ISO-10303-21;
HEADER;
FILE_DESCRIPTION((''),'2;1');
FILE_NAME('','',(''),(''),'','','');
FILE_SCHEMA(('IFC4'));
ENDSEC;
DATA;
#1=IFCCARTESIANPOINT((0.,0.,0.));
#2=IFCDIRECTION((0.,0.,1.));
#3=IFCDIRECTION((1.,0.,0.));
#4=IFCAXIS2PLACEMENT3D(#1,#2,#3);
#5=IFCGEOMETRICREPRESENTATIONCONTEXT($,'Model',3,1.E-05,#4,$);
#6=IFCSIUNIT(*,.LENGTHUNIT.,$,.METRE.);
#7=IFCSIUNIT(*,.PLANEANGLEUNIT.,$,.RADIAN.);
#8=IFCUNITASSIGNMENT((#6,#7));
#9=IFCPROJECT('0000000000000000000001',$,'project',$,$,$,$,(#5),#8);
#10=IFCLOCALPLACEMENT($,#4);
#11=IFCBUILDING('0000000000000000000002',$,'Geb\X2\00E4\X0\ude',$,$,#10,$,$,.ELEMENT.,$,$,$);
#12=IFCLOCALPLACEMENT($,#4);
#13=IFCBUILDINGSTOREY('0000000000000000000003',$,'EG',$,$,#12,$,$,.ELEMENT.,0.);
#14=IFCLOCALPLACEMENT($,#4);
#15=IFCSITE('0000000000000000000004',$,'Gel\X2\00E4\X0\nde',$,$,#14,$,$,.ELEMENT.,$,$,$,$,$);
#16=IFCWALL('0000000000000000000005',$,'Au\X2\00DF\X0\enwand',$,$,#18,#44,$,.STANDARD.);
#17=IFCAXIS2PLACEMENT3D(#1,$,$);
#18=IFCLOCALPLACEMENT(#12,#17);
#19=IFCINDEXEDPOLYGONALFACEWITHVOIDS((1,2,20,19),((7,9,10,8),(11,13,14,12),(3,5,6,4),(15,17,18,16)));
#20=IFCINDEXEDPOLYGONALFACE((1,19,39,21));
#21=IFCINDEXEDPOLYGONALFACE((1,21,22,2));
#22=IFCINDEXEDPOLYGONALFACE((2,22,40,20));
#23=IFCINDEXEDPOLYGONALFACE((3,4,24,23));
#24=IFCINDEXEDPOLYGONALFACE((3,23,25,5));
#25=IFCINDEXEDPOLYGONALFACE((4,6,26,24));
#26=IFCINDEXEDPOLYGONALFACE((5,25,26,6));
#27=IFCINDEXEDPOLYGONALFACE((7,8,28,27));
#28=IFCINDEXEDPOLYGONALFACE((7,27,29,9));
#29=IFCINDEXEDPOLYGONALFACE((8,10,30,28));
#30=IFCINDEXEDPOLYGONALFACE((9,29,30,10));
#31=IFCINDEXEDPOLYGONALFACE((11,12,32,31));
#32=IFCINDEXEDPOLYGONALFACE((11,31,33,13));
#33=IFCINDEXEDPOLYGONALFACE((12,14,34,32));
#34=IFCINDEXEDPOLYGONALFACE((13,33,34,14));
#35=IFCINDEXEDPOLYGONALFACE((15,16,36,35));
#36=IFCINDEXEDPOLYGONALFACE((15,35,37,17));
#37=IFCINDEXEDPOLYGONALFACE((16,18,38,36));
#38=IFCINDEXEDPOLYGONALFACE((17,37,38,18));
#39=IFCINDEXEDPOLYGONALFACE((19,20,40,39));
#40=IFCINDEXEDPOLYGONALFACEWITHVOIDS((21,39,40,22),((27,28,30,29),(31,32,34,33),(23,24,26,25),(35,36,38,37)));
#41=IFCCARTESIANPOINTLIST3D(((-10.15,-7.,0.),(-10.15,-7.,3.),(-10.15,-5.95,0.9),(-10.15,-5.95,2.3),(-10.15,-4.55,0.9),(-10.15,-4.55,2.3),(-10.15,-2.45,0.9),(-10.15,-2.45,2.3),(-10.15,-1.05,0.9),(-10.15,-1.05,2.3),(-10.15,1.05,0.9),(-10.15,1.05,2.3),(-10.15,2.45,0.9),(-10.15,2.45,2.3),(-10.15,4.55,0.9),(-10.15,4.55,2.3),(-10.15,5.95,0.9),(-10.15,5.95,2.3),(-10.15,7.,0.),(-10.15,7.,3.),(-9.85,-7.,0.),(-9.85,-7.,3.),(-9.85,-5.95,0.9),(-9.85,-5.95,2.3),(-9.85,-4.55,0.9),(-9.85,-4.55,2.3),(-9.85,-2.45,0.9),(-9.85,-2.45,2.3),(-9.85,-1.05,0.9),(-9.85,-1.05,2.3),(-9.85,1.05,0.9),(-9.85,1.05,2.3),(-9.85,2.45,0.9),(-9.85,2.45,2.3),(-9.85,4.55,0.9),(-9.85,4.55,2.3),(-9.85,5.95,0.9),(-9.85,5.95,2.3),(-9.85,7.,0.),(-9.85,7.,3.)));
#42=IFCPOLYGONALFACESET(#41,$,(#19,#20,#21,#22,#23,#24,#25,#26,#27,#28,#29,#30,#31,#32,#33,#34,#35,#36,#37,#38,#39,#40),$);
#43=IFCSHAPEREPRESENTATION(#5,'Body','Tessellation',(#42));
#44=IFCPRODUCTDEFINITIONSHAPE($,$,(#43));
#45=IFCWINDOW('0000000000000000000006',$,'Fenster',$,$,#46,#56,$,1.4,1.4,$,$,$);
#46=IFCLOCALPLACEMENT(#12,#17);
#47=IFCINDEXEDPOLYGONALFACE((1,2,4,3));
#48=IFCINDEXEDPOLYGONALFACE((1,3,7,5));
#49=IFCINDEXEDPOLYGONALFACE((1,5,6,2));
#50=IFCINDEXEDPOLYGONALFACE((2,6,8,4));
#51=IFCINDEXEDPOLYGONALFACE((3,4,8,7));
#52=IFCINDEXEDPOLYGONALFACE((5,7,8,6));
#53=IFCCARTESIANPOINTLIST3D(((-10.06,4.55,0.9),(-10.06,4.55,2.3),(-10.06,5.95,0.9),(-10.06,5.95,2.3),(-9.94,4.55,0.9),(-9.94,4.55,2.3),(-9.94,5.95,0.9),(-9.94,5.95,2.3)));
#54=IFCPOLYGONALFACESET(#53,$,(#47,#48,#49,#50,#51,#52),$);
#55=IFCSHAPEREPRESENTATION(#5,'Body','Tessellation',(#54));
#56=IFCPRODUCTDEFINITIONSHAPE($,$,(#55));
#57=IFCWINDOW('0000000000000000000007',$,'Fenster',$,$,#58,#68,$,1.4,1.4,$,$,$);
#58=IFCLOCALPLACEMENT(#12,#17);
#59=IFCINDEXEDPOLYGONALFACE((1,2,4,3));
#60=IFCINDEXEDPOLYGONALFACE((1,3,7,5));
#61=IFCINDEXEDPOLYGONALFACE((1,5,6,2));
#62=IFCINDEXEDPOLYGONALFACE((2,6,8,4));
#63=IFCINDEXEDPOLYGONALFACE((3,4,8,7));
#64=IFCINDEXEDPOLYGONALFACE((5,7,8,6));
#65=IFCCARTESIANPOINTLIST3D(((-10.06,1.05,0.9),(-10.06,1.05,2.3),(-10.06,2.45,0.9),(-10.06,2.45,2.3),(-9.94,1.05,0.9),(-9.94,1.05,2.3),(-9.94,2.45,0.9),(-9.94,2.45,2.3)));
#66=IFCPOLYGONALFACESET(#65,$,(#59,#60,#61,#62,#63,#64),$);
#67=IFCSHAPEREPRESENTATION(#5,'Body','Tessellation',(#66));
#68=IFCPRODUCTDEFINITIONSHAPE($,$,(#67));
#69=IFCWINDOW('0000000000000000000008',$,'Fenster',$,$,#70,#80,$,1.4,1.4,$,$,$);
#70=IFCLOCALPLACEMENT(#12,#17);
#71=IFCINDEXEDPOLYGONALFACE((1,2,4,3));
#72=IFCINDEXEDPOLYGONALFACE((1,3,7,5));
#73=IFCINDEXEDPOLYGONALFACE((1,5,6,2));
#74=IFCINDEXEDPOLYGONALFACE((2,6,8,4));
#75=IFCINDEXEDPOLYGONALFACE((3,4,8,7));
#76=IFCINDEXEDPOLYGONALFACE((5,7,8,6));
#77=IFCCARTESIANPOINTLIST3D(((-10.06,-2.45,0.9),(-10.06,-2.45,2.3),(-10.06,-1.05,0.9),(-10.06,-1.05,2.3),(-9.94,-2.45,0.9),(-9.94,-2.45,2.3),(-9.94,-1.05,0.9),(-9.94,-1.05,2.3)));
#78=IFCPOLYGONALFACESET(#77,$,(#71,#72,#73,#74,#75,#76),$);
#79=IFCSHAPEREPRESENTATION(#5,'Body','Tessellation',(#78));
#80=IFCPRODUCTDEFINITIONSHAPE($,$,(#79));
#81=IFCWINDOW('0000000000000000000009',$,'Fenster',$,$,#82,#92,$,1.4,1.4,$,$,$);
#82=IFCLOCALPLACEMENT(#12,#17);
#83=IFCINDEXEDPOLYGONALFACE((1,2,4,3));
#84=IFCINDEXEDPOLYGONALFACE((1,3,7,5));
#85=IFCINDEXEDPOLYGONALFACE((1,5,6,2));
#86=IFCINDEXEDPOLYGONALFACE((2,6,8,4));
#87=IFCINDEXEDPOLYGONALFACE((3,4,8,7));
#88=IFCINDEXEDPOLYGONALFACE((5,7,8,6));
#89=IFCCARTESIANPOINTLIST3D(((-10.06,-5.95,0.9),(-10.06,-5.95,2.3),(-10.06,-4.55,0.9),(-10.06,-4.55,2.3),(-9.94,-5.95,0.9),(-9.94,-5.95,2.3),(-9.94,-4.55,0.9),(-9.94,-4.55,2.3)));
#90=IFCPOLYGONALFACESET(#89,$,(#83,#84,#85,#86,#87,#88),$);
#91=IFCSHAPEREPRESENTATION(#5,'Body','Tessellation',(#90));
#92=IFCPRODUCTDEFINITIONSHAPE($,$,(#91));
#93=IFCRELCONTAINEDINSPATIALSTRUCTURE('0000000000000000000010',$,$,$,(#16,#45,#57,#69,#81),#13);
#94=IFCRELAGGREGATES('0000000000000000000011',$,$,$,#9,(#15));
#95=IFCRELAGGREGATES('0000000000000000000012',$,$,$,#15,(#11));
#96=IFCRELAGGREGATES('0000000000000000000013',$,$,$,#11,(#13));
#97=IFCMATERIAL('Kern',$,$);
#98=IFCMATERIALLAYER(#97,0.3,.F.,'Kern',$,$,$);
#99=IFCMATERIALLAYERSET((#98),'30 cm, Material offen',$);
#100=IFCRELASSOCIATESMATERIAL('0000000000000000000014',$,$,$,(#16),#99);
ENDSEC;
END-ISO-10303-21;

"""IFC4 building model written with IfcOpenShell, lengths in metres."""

from ifc_helpers import new_model, si_unit, frame, origin_with_axes, origin_2d, place, context, project, spatial, rectangle, extrude, material, layer, layer_set, element, fill, save


model = new_model("IFC4")

# Units and contexts
model_context = context("Model", 3, precision=1e-05, world=origin_with_axes())
ifc_project = project(units=[si_unit("LENGTHUNIT", "METRE"), si_unit("PLANEANGLEUNIT", "RADIAN")], contexts=[model_context])

# Site, building, storey
site_placement = place(None, origin_with_axes())
site = spatial("IfcSite", under=ifc_project, at=site_placement, Name="Gelände", CompositionType="ELEMENT")
building_placement = place(None, origin_with_axes())
building = spatial("IfcBuilding", under=site, at=building_placement, Name="Gebäude", CompositionType="ELEMENT")
storey_placement = place(None, origin_with_axes())
storey = spatial("IfcBuildingStorey", under=building, at=storey_placement, Name="EG", CompositionType="ELEMENT", Elevation=0.0)

# Shared definitions
ifc_material = material(Name="Kern")
ifc_layer = layer(ifc_material, 0.3, ventilated=False, Name="Kern")
ifc_layer_set = layer_set([ifc_layer], Name="30 cm, Material offen")

# Wall, openings, windows
wall_1_placement = place(None, frame((-10.0, 0.0, 0.0), z_axis=(0.0, 0.0, 1.0), x_axis=(0.0, -1.0, 0.0)))
wall_1 = element("IfcWall", 1, at=wall_1_placement, inside=storey, material=ifc_layer_set, Name="Außenwand", PredefinedType="STANDARD", context=model_context, shape_type="SweptSolid", body=[
    extrude(rectangle(XDim=14.0, YDim=0.3, at=origin_2d()), origin_with_axes(), (0.0, 0.0, 1.0), 3.0),
])
opening_1_placement = place(wall_1_placement, frame((-5.25, 0.0, 0.9), z_axis=(0.0, 0.0, 1.0), x_axis=(1.0, 0.0, 0.0)))
opening_1 = element("IfcOpeningElement", 2, at=opening_1_placement, cuts=wall_1, PredefinedType="OPENING", context=model_context, shape_type="SweptSolid", body=[
    extrude(rectangle(XDim=1.4, YDim=0.34, at=origin_2d()), origin_with_axes(), (0.0, 0.0, 1.0), 1.4),
])
opening_2_placement = place(wall_1_placement, frame((-1.75, 0.0, 0.9), z_axis=(0.0, 0.0, 1.0), x_axis=(1.0, 0.0, 0.0)))
opening_2 = element("IfcOpeningElement", 3, at=opening_2_placement, cuts=wall_1, PredefinedType="OPENING", context=model_context, shape_type="SweptSolid", body=[
    extrude(rectangle(XDim=1.4, YDim=0.34, at=origin_2d()), origin_with_axes(), (0.0, 0.0, 1.0), 1.4),
])
opening_3_placement = place(wall_1_placement, frame((1.75, 0.0, 0.9), z_axis=(0.0, 0.0, 1.0), x_axis=(1.0, 0.0, 0.0)))
opening_3 = element("IfcOpeningElement", 4, at=opening_3_placement, cuts=wall_1, PredefinedType="OPENING", context=model_context, shape_type="SweptSolid", body=[
    extrude(rectangle(XDim=1.4, YDim=0.34, at=origin_2d()), origin_with_axes(), (0.0, 0.0, 1.0), 1.4),
])
opening_4_placement = place(wall_1_placement, frame((5.25, 0.0, 0.9), z_axis=(0.0, 0.0, 1.0), x_axis=(1.0, 0.0, 0.0)))
opening_4 = element("IfcOpeningElement", 5, at=opening_4_placement, cuts=wall_1, PredefinedType="OPENING", context=model_context, shape_type="SweptSolid", body=[
    extrude(rectangle(XDim=1.4, YDim=0.34, at=origin_2d()), origin_with_axes(), (0.0, 0.0, 1.0), 1.4),
])
window_1_placement = place(opening_1_placement, origin_with_axes())
window_1 = element("IfcWindow", 6, at=window_1_placement, inside=storey, Name="Fenster", OverallHeight=1.4, OverallWidth=1.4, context=model_context, shape_type="SweptSolid", body=[
    extrude(rectangle(XDim=1.4, YDim=0.12, at=origin_2d()), origin_with_axes(), (0.0, 0.0, 1.0), 1.4),
])
fill(opening_1, window_1)
window_2_placement = place(opening_2_placement, origin_with_axes())
window_2 = element("IfcWindow", 7, at=window_2_placement, inside=storey, Name="Fenster", OverallHeight=1.4, OverallWidth=1.4, context=model_context, shape_type="SweptSolid", body=[
    extrude(rectangle(XDim=1.4, YDim=0.12, at=origin_2d()), origin_with_axes(), (0.0, 0.0, 1.0), 1.4),
])
fill(opening_2, window_2)
window_3_placement = place(opening_3_placement, origin_with_axes())
window_3 = element("IfcWindow", 8, at=window_3_placement, inside=storey, Name="Fenster", OverallHeight=1.4, OverallWidth=1.4, context=model_context, shape_type="SweptSolid", body=[
    extrude(rectangle(XDim=1.4, YDim=0.12, at=origin_2d()), origin_with_axes(), (0.0, 0.0, 1.0), 1.4),
])
fill(opening_3, window_3)
window_4_placement = place(opening_4_placement, origin_with_axes())
window_4 = element("IfcWindow", 9, at=window_4_placement, inside=storey, Name="Fenster", OverallHeight=1.4, OverallWidth=1.4, context=model_context, shape_type="SweptSolid", body=[
    extrude(rectangle(XDim=1.4, YDim=0.12, at=origin_2d()), origin_with_axes(), (0.0, 0.0, 1.0), 1.4),
])
fill(opening_4, window_4)

save(model, "model.ifc")
